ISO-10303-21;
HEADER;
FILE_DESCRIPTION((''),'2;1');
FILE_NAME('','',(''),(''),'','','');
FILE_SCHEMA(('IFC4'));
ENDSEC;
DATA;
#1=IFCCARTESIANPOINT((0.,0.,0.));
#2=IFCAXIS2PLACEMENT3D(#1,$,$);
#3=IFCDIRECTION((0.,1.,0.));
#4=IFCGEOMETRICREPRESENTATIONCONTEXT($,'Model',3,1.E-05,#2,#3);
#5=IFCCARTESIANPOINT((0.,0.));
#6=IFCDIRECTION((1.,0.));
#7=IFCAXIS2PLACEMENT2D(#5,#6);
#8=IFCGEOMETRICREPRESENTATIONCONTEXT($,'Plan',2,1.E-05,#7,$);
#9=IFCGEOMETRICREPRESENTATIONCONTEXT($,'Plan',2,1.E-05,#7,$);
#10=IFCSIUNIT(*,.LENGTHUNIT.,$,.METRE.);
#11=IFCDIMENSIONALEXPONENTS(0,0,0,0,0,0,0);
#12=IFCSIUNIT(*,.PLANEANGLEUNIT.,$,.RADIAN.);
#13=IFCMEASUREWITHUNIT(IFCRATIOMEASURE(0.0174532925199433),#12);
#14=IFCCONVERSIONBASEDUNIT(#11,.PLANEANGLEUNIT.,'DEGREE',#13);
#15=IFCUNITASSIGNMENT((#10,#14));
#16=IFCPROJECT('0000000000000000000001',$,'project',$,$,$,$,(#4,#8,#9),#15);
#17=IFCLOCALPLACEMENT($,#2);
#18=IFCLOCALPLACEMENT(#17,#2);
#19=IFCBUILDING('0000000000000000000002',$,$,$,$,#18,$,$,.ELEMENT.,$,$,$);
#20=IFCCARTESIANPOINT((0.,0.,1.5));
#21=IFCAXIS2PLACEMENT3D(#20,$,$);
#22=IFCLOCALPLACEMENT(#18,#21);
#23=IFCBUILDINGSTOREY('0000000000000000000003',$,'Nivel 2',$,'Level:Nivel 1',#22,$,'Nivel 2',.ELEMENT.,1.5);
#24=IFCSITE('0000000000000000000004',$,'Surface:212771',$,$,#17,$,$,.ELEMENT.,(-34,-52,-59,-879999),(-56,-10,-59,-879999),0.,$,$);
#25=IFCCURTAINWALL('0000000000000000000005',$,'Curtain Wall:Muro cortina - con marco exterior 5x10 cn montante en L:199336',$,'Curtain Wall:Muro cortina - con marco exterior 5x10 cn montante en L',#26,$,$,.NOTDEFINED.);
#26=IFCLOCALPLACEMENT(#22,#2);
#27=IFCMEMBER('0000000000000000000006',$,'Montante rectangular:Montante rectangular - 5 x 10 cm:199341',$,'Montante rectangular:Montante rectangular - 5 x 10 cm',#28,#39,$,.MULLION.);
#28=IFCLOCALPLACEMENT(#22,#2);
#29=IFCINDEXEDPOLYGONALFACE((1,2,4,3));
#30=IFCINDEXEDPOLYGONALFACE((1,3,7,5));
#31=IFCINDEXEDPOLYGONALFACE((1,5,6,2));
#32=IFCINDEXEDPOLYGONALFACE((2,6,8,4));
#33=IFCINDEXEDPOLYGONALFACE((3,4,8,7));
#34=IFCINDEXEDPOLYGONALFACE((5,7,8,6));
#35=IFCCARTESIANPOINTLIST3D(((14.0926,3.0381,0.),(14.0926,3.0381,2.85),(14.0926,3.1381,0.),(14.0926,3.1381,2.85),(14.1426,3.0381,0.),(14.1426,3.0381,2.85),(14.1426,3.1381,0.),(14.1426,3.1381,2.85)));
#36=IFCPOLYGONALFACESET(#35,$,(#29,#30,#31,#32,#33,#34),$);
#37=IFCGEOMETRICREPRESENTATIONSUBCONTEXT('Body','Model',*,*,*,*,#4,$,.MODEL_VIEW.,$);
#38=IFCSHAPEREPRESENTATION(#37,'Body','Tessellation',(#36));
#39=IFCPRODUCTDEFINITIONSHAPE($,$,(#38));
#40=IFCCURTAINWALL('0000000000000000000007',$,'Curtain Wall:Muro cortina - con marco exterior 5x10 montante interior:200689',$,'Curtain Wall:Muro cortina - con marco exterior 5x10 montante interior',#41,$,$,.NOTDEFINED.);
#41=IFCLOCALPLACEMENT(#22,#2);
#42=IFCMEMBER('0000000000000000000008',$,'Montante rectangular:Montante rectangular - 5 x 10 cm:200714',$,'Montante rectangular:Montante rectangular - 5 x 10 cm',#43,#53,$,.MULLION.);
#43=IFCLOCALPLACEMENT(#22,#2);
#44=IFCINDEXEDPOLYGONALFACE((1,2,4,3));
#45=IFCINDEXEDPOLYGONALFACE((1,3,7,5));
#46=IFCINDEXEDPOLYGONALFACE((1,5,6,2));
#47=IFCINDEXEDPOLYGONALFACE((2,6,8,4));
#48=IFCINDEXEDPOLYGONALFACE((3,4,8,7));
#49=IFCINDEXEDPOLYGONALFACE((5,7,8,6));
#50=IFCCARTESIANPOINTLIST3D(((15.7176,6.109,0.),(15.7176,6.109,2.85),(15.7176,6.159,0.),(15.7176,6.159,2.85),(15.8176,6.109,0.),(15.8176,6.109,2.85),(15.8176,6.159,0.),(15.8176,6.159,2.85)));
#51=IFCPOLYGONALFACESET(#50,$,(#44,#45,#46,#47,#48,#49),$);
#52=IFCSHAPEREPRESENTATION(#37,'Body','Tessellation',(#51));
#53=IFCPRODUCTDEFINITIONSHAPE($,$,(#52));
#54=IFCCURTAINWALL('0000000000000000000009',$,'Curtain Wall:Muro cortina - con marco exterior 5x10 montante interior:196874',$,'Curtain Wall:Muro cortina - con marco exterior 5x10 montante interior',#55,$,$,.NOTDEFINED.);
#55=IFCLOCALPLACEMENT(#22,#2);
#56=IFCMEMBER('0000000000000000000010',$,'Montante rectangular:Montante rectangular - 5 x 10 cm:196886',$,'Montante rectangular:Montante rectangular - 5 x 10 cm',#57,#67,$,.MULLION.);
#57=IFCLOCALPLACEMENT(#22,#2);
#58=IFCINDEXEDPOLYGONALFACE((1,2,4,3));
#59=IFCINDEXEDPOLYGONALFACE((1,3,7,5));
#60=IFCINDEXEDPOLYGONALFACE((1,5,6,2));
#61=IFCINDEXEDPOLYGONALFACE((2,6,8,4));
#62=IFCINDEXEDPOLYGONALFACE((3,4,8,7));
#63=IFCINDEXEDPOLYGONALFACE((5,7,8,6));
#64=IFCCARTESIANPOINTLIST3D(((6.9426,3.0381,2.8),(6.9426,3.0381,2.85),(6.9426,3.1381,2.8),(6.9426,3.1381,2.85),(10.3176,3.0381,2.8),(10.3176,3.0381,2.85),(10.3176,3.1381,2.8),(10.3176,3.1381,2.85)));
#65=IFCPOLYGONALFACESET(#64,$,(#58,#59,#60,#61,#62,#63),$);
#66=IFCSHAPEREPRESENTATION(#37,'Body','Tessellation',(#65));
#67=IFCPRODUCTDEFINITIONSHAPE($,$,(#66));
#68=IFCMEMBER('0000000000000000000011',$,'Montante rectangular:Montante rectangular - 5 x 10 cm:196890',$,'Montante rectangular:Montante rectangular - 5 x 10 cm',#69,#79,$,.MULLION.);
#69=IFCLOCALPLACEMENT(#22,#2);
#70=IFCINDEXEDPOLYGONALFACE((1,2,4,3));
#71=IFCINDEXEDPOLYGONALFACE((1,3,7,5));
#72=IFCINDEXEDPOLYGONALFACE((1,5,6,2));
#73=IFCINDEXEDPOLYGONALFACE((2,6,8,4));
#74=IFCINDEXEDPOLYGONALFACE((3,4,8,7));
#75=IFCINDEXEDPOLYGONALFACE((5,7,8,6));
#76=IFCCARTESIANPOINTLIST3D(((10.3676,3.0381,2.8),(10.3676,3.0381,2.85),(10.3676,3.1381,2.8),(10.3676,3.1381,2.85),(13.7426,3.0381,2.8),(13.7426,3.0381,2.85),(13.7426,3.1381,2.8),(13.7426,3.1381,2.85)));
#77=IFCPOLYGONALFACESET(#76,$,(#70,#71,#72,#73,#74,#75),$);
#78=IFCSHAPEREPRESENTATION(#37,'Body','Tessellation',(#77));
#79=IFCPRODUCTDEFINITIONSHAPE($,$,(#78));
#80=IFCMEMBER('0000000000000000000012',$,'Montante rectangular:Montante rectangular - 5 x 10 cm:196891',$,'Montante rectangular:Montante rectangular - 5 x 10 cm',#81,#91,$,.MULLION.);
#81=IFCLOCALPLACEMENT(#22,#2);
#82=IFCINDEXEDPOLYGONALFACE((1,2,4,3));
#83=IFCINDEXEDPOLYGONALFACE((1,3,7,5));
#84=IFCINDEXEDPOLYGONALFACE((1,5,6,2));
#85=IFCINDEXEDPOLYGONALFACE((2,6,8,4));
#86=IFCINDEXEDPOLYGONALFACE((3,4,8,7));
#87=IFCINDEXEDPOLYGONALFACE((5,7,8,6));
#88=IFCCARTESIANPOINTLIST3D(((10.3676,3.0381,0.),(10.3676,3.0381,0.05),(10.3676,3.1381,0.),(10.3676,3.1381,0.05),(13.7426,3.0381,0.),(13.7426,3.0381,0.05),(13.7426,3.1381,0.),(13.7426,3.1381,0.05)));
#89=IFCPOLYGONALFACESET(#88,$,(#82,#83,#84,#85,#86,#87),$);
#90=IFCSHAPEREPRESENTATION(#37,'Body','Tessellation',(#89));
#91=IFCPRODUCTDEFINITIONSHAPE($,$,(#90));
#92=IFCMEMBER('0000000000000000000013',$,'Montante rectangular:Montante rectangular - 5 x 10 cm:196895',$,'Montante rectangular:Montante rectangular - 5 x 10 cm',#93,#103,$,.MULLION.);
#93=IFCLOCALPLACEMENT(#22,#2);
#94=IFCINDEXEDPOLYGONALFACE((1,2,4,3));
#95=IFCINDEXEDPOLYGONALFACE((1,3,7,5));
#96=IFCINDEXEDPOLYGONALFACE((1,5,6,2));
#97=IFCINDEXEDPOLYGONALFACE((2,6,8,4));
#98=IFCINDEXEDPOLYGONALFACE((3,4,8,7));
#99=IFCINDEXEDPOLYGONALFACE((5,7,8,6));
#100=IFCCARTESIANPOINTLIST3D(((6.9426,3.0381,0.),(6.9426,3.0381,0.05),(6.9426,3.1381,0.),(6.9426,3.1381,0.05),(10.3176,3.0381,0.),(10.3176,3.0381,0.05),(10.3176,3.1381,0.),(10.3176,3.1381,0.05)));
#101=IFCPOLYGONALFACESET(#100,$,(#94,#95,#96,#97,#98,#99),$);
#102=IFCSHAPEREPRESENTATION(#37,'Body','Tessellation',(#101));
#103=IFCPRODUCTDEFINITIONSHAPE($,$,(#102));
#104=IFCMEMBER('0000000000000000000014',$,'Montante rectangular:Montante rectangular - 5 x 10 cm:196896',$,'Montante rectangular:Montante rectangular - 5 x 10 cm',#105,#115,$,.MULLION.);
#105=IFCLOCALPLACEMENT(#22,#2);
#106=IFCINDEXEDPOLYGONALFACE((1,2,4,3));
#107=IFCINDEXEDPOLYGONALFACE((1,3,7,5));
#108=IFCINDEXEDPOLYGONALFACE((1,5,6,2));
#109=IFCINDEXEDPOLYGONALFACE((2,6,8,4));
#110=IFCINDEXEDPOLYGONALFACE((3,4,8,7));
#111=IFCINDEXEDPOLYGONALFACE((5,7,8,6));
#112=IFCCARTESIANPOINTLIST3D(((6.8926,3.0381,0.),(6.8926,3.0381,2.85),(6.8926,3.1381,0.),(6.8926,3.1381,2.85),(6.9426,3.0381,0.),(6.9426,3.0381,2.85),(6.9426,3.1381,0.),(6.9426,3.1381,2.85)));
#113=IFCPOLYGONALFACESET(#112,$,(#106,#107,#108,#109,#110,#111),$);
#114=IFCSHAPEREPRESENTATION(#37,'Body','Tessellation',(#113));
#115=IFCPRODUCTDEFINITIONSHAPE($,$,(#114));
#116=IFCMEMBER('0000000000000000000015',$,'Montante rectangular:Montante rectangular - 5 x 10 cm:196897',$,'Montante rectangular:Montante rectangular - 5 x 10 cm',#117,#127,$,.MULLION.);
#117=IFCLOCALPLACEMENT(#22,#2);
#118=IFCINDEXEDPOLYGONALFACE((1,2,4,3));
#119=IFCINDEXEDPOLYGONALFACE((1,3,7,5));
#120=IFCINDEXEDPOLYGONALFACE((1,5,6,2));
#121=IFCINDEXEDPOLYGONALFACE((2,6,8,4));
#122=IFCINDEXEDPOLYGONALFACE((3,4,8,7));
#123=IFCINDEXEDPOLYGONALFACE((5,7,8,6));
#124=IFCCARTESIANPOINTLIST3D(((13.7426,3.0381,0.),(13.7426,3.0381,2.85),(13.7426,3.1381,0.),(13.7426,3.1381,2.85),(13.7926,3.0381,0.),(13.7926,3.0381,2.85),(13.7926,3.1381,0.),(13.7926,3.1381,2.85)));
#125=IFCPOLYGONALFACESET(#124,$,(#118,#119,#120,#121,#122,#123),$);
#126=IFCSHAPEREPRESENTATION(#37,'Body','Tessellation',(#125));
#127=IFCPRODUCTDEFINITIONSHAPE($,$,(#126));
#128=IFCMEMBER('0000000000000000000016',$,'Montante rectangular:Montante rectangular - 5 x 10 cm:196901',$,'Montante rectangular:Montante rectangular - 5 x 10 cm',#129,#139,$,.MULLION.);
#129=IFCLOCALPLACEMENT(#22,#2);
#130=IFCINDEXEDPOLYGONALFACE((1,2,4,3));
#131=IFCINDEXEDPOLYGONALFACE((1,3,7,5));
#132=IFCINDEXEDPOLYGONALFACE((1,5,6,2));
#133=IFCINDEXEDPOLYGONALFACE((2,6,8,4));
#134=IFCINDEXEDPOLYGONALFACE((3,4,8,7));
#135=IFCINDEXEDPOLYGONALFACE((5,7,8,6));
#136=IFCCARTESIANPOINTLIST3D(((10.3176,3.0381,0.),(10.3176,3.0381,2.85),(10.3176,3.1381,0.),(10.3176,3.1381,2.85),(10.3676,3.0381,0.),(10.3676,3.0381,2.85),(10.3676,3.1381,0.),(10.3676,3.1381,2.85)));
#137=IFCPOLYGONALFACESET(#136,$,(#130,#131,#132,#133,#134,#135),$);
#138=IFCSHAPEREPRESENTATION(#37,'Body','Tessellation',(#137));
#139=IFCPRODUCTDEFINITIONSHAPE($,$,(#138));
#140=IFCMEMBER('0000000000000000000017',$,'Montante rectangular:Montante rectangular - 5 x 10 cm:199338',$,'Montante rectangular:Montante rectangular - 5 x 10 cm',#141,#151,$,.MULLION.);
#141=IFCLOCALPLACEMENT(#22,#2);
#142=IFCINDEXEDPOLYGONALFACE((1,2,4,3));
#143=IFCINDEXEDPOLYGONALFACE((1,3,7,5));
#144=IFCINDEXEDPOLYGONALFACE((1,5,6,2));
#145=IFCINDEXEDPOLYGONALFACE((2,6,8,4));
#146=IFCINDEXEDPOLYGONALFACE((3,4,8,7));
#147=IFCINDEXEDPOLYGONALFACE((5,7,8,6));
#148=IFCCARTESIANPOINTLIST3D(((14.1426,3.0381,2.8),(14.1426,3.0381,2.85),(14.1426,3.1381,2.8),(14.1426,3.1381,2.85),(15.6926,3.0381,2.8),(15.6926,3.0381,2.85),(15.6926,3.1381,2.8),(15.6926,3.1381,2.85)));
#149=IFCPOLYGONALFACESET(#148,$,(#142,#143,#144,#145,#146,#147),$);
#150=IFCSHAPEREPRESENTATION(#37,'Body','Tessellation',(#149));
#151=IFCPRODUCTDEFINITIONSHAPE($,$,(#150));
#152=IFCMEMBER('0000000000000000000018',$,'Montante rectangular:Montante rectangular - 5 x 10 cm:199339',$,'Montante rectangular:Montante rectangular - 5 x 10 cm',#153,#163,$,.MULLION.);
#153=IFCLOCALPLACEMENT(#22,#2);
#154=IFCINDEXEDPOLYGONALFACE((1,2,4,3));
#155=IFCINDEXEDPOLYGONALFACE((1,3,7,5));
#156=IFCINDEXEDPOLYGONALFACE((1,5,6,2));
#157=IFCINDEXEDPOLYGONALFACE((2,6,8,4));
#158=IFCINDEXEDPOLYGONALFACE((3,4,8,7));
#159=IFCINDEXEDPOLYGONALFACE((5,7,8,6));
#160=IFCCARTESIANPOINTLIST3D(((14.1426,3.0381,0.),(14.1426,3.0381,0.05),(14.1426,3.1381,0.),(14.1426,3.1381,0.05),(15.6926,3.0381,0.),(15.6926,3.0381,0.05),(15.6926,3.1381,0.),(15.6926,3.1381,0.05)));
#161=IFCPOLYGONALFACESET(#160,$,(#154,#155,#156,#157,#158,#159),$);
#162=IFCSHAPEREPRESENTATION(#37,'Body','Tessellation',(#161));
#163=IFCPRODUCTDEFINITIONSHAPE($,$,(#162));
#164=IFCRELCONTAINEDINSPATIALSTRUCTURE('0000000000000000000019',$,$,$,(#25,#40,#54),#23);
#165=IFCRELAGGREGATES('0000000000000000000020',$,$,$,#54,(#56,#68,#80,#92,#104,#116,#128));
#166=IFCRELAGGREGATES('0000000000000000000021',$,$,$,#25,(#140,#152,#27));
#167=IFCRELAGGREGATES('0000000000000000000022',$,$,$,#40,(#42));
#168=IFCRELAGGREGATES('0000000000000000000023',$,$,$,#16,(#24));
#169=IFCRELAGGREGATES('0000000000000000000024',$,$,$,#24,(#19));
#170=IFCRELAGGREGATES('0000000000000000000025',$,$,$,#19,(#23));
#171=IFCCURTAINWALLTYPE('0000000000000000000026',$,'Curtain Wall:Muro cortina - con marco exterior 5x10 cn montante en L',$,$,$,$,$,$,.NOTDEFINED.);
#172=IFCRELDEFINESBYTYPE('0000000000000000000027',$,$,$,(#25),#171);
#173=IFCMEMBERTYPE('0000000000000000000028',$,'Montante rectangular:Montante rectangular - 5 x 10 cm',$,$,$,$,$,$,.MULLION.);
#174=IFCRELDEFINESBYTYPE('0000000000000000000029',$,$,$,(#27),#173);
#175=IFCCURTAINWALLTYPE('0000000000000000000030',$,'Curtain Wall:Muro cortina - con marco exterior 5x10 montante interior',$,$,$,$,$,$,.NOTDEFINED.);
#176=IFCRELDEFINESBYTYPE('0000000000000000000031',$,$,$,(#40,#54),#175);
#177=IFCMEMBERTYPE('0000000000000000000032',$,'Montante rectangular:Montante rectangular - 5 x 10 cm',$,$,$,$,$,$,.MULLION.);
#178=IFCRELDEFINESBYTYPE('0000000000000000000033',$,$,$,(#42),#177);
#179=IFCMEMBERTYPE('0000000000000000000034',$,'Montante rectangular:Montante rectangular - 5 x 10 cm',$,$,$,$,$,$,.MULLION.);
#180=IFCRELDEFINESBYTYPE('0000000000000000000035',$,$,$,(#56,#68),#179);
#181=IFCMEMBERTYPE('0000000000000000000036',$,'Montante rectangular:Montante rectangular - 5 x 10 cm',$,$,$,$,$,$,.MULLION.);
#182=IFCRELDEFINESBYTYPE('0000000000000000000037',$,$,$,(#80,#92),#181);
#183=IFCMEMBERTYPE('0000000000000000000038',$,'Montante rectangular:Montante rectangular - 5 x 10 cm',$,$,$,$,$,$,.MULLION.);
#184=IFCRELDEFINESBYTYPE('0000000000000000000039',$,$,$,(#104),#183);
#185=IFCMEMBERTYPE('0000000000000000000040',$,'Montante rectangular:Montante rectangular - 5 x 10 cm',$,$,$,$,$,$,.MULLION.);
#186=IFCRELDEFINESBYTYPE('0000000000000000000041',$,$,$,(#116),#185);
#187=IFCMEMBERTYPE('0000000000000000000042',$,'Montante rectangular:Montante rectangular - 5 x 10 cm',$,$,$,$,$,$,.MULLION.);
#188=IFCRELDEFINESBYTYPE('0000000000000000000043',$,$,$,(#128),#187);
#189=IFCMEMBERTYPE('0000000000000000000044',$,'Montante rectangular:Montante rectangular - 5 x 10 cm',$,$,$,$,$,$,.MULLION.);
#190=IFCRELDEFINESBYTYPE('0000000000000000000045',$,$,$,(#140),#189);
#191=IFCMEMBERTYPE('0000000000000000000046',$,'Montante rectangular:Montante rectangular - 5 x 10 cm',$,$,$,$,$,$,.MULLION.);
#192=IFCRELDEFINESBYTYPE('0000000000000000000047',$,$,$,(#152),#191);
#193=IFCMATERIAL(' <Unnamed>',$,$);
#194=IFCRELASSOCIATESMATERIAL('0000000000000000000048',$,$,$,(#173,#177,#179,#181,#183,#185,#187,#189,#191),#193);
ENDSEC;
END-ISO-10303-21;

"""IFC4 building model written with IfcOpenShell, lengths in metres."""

from ifc_helpers import new_model, entity, si_unit, converted_unit, direction, frame, origin, origin_2d_with_axis, place, context, subcontext, project, spatial, indexed_curve, outline, extrude, source, transform, mapped, material, type_object, type_shapes, element, aggregate, save


model = new_model("IFC4")

# Units and contexts
model_context = context("Model", 3, precision=1e-05, world=origin(), true_north=direction((0.0, 1.0, 0.0)))
plan_context_1 = context("Plan", 2, precision=1e-05, world=origin_2d_with_axis())
plan_context_2 = context("Plan", 2, precision=1e-05, world=origin_2d_with_axis())
body_context = subcontext(model_context, "Body", "Model", "MODEL_VIEW")
ifc_project = project(units=[si_unit("LENGTHUNIT", "METRE"), converted_unit("PLANEANGLEUNIT", "DEGREE", entity("IfcRatioMeasure", 0.0174532925199433), si_unit("PLANEANGLEUNIT", "RADIAN"), dimensions=[0, 0, 0, 0, 0, 0, 0])], contexts=[model_context, plan_context_1, plan_context_2])

# Site, building, storey
site_placement = place(None, origin())
site = spatial("IfcSite", under=ifc_project, at=site_placement, Name="Surface:212771", CompositionType="ELEMENT", RefLatitude=(-34, -52, -59, -879999), RefLongitude=(-56, -10, -59, -879999), RefElevation=0.0)
building_placement = place(site_placement, origin())
building = spatial("IfcBuilding", under=site, at=building_placement, CompositionType="ELEMENT")
storey_placement = place(building_placement, frame((0.0, 0.0, 1.5)))
storey = spatial("IfcBuildingStorey", under=building, at=storey_placement, Name="Nivel 2", ObjectType="Level:Nivel 1", LongName="Nivel 2", CompositionType="ELEMENT", Elevation=1.5)

# Curtain walls, members
curtain_wall_type_1 = type_object("IfcCurtainWallType", Name="Curtain Wall:Muro cortina - con marco exterior 5x10 cn montante en L", PredefinedType="NOTDEFINED")
curtain_wall_1_placement = place(storey_placement, frame((0.0, 0.0, -1.5)))
curtain_wall_1 = element("IfcCurtainWall", 1, at=curtain_wall_1_placement, inside=storey, type_object=curtain_wall_type_1, Name="Curtain Wall:Muro cortina - con marco exterior 5x10 cn montante en L:199336", ObjectType="Curtain Wall:Muro cortina - con marco exterior 5x10 cn montante en L", PredefinedType="NOTDEFINED")
ifc_material_1 = material(Name=" <Unnamed>")
member_type_1 = type_object("IfcMemberType", Name="Montante rectangular:Montante rectangular - 5 x 10 cm", PredefinedType="MULLION", material=ifc_material_1)
shared_shape_1 = source(origin(), body_context, "Body", "SweptSolid", [
    extrude(outline(indexed_curve([(-0.05, -0.025), (0.05, -0.025), (0.05, 0.025), (-0.05, 0.025), (-0.05, -0.025)], self_intersect=False)), frame((-0.025, 0.0, -2.85), z_axis=(0.0, 0.0, 1.0), x_axis=(0.0, -1.0, 0.0)), (0.0, 0.0, 1.0), 2.85),
])
type_shapes(member_type_1, [shared_shape_1])
member_1_placement = place(storey_placement, frame((14.0926, 3.0881, 2.85), z_axis=(0.0, 0.0, 1.0), x_axis=(-1.0, 0.0, 0.0)))
member_1 = element("IfcMember", 2, at=member_1_placement, type_object=member_type_1, Name="Montante rectangular:Montante rectangular - 5 x 10 cm:199341", ObjectType="Montante rectangular:Montante rectangular - 5 x 10 cm", PredefinedType="MULLION", context=body_context, shape_type="MappedRepresentation", body=[
    mapped(shared_shape_1, transform((0.0, 0.0, 0.0), scale=1.0)),
])
curtain_wall_type_2 = type_object("IfcCurtainWallType", Name="Curtain Wall:Muro cortina - con marco exterior 5x10 montante interior", PredefinedType="NOTDEFINED")
curtain_wall_2_placement = place(storey_placement, frame((0.0, 0.0, -1.5)))
curtain_wall_2 = element("IfcCurtainWall", 3, at=curtain_wall_2_placement, inside=storey, type_object=curtain_wall_type_2, Name="Curtain Wall:Muro cortina - con marco exterior 5x10 montante interior:200689", ObjectType="Curtain Wall:Muro cortina - con marco exterior 5x10 montante interior", PredefinedType="NOTDEFINED")
member_type_2 = type_object("IfcMemberType", Name="Montante rectangular:Montante rectangular - 5 x 10 cm", PredefinedType="MULLION", material=ifc_material_1)
shared_shape_2 = source(origin(), body_context, "Body", "SweptSolid", [
    extrude(outline(indexed_curve([(-0.05, -0.025), (0.05, -0.025), (0.05, 0.025), (-0.05, 0.025), (-0.05, -0.025)], self_intersect=False)), frame((0.0, 0.0, -2.85), z_axis=(0.0, 0.0, 1.0), x_axis=(0.0, -1.0, 0.0)), (0.0, 0.0, 1.0), 2.85),
])
type_shapes(member_type_2, [shared_shape_2])
member_2_placement = place(storey_placement, frame((15.7676, 6.134, 0.0), z_axis=(0.0, 0.0, -1.0), x_axis=(0.0, 1.0, 0.0)))
member_2 = element("IfcMember", 4, at=member_2_placement, type_object=member_type_2, Name="Montante rectangular:Montante rectangular - 5 x 10 cm:200714", ObjectType="Montante rectangular:Montante rectangular - 5 x 10 cm", PredefinedType="MULLION", context=body_context, shape_type="MappedRepresentation", body=[
    mapped(shared_shape_2, transform((0.0, 0.0, 0.0), scale=1.0)),
])

# Curtain wall, members
curtain_wall_3_placement = place(storey_placement, frame((0.0, 0.0, -1.5)))
curtain_wall_3 = element("IfcCurtainWall", 5, at=curtain_wall_3_placement, inside=storey, type_object=curtain_wall_type_2, Name="Curtain Wall:Muro cortina - con marco exterior 5x10 montante interior:196874", ObjectType="Curtain Wall:Muro cortina - con marco exterior 5x10 montante interior", PredefinedType="NOTDEFINED")
member_type_3 = type_object("IfcMemberType", Name="Montante rectangular:Montante rectangular - 5 x 10 cm", PredefinedType="MULLION", material=ifc_material_1)
shared_shape_3 = source(origin(), body_context, "Body", "SweptSolid", [
    extrude(outline(indexed_curve([(-0.05, -0.025), (0.05, -0.025), (0.05, 0.025), (-0.05, 0.025), (-0.05, -0.025)], self_intersect=False)), frame((-0.025, 0.0, -3.375), z_axis=(0.0, 0.0, 1.0), x_axis=(0.0, -1.0, 0.0)), (0.0, 0.0, 1.0), 3.375),
])
type_shapes(member_type_3, [shared_shape_3])
placement = place(building_placement, frame((0.0, 0.0, 0.75)))
member_3_placement = place(placement, frame((6.9426, 3.0881, 3.6), z_axis=(-1.0, 0.0, 0.0), x_axis=(0.0, 0.0, 1.0)))
member_3 = element("IfcMember", 6, at=member_3_placement, type_object=member_type_3, Name="Montante rectangular:Montante rectangular - 5 x 10 cm:196886", ObjectType="Montante rectangular:Montante rectangular - 5 x 10 cm", PredefinedType="MULLION", context=body_context, shape_type="MappedRepresentation", body=[
    mapped(shared_shape_3, transform((0.0, 0.0, 0.0), scale=1.0)),
])
member_4_placement = place(placement, frame((10.3676, 3.0881, 3.6), z_axis=(-1.0, 0.0, 0.0), x_axis=(0.0, 0.0, 1.0)))
member_4 = element("IfcMember", 7, at=member_4_placement, type_object=member_type_3, Name="Montante rectangular:Montante rectangular - 5 x 10 cm:196890", ObjectType="Montante rectangular:Montante rectangular - 5 x 10 cm", PredefinedType="MULLION", context=body_context, shape_type="MappedRepresentation", body=[
    mapped(shared_shape_3, transform((0.0, 0.0, 0.0), scale=1.0)),
])
member_type_4 = type_object("IfcMemberType", Name="Montante rectangular:Montante rectangular - 5 x 10 cm", PredefinedType="MULLION", material=ifc_material_1)
shared_shape_4 = source(origin(), body_context, "Body", "SweptSolid", [
    extrude(outline(indexed_curve([(-0.05, -0.025), (0.05, -0.025), (0.05, 0.025), (-0.05, 0.025), (-0.05, -0.025)], self_intersect=False)), frame((-0.025, 0.0, -3.375), z_axis=(0.0, 0.0, 1.0), x_axis=(0.0, -1.0, 0.0)), (0.0, 0.0, 1.0), 3.375),
])
type_shapes(member_type_4, [shared_shape_4])
member_5_placement = place(placement, frame((13.7426, 3.0881, 0.75), z_axis=(1.0, 0.0, 0.0), x_axis=(0.0, 0.0, -1.0)))
member_5 = element("IfcMember", 8, at=member_5_placement, type_object=member_type_4, Name="Montante rectangular:Montante rectangular - 5 x 10 cm:196891", ObjectType="Montante rectangular:Montante rectangular - 5 x 10 cm", PredefinedType="MULLION", context=body_context, shape_type="MappedRepresentation", body=[
    mapped(shared_shape_4, transform((0.0, 0.0, 0.0), scale=1.0)),
])
member_6_placement = place(placement, frame((10.3176, 3.0881, 0.75), z_axis=(1.0, 0.0, 0.0), x_axis=(0.0, 0.0, -1.0)))
member_6 = element("IfcMember", 9, at=member_6_placement, type_object=member_type_4, Name="Montante rectangular:Montante rectangular - 5 x 10 cm:196895", ObjectType="Montante rectangular:Montante rectangular - 5 x 10 cm", PredefinedType="MULLION", context=body_context, shape_type="MappedRepresentation", body=[
    mapped(shared_shape_4, transform((0.0, 0.0, 0.0), scale=1.0)),
])
member_type_5 = type_object("IfcMemberType", Name="Montante rectangular:Montante rectangular - 5 x 10 cm", PredefinedType="MULLION", material=ifc_material_1)
shared_shape_5 = source(origin(), body_context, "Body", "SweptSolid", [
    extrude(outline(indexed_curve([(-0.05, -0.025), (0.05, -0.025), (0.05, 0.025), (-0.05, 0.025), (-0.05, -0.025)], self_intersect=False)), frame((-0.025, 0.0, -2.85), z_axis=(0.0, 0.0, 1.0), x_axis=(0.0, -1.0, 0.0)), (0.0, 0.0, 1.0), 2.85),
])
type_shapes(member_type_5, [shared_shape_5])
member_7_placement = place(placement, frame((6.8926, 3.0881, 0.75), z_axis=(0.0, 0.0, -1.0), x_axis=(-1.0, 0.0, 0.0)))
member_7 = element("IfcMember", 10, at=member_7_placement, type_object=member_type_5, Name="Montante rectangular:Montante rectangular - 5 x 10 cm:196896", ObjectType="Montante rectangular:Montante rectangular - 5 x 10 cm", PredefinedType="MULLION", context=body_context, shape_type="MappedRepresentation", body=[
    mapped(shared_shape_5, transform((0.0, 0.0, 0.0), scale=1.0)),
])
member_type_6 = type_object("IfcMemberType", Name="Montante rectangular:Montante rectangular - 5 x 10 cm", PredefinedType="MULLION", material=ifc_material_1)
shared_shape_6 = source(origin(), body_context, "Body", "SweptSolid", [
    extrude(outline(indexed_curve([(-0.05, -0.025), (0.05, -0.025), (0.05, 0.025), (-0.05, 0.025), (-0.05, -0.025)], self_intersect=False)), frame((-0.025, 0.0, -2.85), z_axis=(0.0, 0.0, 1.0), x_axis=(0.0, -1.0, 0.0)), (0.0, 0.0, 1.0), 2.85),
])
type_shapes(member_type_6, [shared_shape_6])
member_8_placement = place(placement, frame((13.7926, 3.0881, 3.6)))
member_8 = element("IfcMember", 11, at=member_8_placement, type_object=member_type_6, Name="Montante rectangular:Montante rectangular - 5 x 10 cm:196897", ObjectType="Montante rectangular:Montante rectangular - 5 x 10 cm", PredefinedType="MULLION", context=body_context, shape_type="MappedRepresentation", body=[
    mapped(shared_shape_6, transform((0.0, 0.0, 0.0), scale=1.0)),
])
member_type_7 = type_object("IfcMemberType", Name="Montante rectangular:Montante rectangular - 5 x 10 cm", PredefinedType="MULLION", material=ifc_material_1)
shared_shape_7 = source(origin(), body_context, "Body", "SweptSolid", [
    extrude(outline(indexed_curve([(-0.05, -0.025), (0.05, -0.025), (0.05, 0.025), (-0.05, 0.025), (-0.05, -0.025)], self_intersect=False)), frame((0.0, 0.0, -2.85), z_axis=(0.0, 0.0, 1.0), x_axis=(0.0, -1.0, 0.0)), (0.0, 0.0, 1.0), 2.85),
])
type_shapes(member_type_7, [shared_shape_7])
member_9_placement = place(placement, frame((10.3426, 3.0881, 0.75), z_axis=(0.0, 0.0, -1.0), x_axis=(-1.0, 0.0, 0.0)))
member_9 = element("IfcMember", 12, at=member_9_placement, type_object=member_type_7, Name="Montante rectangular:Montante rectangular - 5 x 10 cm:196901", ObjectType="Montante rectangular:Montante rectangular - 5 x 10 cm", PredefinedType="MULLION", context=body_context, shape_type="MappedRepresentation", body=[
    mapped(shared_shape_7, transform((0.0, 0.0, 0.0), scale=1.0)),
])

# Members
member_type_8 = type_object("IfcMemberType", Name="Montante rectangular:Montante rectangular - 5 x 10 cm", PredefinedType="MULLION", material=ifc_material_1)
shared_shape_8 = source(origin(), body_context, "Body", "SweptSolid", [
    extrude(outline(indexed_curve([(-0.05, -0.025), (0.05, -0.025), (0.05, 0.025), (-0.05, 0.025), (-0.05, -0.025)], self_intersect=False)), frame((-0.025, 0.0, -1.55), z_axis=(0.0, 0.0, 1.0), x_axis=(0.0, -1.0, 0.0)), (0.0, 0.0, 1.0), 1.55),
])
type_shapes(member_type_8, [shared_shape_8])
member_10_placement = place(storey_placement, frame((15.6926, 3.0881, 2.85), z_axis=(1.0, 0.0, 0.0), x_axis=(0.0, 0.0, 1.0)))
member_10 = element("IfcMember", 13, at=member_10_placement, type_object=member_type_8, Name="Montante rectangular:Montante rectangular - 5 x 10 cm:199338", ObjectType="Montante rectangular:Montante rectangular - 5 x 10 cm", PredefinedType="MULLION", context=body_context, shape_type="MappedRepresentation", body=[
    mapped(shared_shape_8, transform((0.0, 0.0, 0.0), scale=1.0)),
])
member_type_9 = type_object("IfcMemberType", Name="Montante rectangular:Montante rectangular - 5 x 10 cm", PredefinedType="MULLION", material=ifc_material_1)
shared_shape_9 = source(origin(), body_context, "Body", "SweptSolid", [
    extrude(outline(indexed_curve([(-0.05, -0.025), (0.05, -0.025), (0.05, 0.025), (-0.05, 0.025), (-0.05, -0.025)], self_intersect=False)), frame((-0.025, 0.0, -1.55), z_axis=(0.0, 0.0, 1.0), x_axis=(0.0, -1.0, 0.0)), (0.0, 0.0, 1.0), 1.55),
])
type_shapes(member_type_9, [shared_shape_9])
member_11_placement = place(storey_placement, frame((14.1426, 3.0881, 0.0), z_axis=(-1.0, 0.0, 0.0), x_axis=(0.0, 0.0, -1.0)))
member_11 = element("IfcMember", 14, at=member_11_placement, type_object=member_type_9, Name="Montante rectangular:Montante rectangular - 5 x 10 cm:199339", ObjectType="Montante rectangular:Montante rectangular - 5 x 10 cm", PredefinedType="MULLION", context=body_context, shape_type="MappedRepresentation", body=[
    mapped(shared_shape_9, transform((0.0, 0.0, 0.0), scale=1.0)),
])

aggregate(curtain_wall_3, [member_3, member_4, member_5, member_6, member_7, member_8, member_9])
aggregate(curtain_wall_1, [member_10, member_11, member_1])
aggregate(curtain_wall_2, [member_2])

save(model, "model.ifc")
